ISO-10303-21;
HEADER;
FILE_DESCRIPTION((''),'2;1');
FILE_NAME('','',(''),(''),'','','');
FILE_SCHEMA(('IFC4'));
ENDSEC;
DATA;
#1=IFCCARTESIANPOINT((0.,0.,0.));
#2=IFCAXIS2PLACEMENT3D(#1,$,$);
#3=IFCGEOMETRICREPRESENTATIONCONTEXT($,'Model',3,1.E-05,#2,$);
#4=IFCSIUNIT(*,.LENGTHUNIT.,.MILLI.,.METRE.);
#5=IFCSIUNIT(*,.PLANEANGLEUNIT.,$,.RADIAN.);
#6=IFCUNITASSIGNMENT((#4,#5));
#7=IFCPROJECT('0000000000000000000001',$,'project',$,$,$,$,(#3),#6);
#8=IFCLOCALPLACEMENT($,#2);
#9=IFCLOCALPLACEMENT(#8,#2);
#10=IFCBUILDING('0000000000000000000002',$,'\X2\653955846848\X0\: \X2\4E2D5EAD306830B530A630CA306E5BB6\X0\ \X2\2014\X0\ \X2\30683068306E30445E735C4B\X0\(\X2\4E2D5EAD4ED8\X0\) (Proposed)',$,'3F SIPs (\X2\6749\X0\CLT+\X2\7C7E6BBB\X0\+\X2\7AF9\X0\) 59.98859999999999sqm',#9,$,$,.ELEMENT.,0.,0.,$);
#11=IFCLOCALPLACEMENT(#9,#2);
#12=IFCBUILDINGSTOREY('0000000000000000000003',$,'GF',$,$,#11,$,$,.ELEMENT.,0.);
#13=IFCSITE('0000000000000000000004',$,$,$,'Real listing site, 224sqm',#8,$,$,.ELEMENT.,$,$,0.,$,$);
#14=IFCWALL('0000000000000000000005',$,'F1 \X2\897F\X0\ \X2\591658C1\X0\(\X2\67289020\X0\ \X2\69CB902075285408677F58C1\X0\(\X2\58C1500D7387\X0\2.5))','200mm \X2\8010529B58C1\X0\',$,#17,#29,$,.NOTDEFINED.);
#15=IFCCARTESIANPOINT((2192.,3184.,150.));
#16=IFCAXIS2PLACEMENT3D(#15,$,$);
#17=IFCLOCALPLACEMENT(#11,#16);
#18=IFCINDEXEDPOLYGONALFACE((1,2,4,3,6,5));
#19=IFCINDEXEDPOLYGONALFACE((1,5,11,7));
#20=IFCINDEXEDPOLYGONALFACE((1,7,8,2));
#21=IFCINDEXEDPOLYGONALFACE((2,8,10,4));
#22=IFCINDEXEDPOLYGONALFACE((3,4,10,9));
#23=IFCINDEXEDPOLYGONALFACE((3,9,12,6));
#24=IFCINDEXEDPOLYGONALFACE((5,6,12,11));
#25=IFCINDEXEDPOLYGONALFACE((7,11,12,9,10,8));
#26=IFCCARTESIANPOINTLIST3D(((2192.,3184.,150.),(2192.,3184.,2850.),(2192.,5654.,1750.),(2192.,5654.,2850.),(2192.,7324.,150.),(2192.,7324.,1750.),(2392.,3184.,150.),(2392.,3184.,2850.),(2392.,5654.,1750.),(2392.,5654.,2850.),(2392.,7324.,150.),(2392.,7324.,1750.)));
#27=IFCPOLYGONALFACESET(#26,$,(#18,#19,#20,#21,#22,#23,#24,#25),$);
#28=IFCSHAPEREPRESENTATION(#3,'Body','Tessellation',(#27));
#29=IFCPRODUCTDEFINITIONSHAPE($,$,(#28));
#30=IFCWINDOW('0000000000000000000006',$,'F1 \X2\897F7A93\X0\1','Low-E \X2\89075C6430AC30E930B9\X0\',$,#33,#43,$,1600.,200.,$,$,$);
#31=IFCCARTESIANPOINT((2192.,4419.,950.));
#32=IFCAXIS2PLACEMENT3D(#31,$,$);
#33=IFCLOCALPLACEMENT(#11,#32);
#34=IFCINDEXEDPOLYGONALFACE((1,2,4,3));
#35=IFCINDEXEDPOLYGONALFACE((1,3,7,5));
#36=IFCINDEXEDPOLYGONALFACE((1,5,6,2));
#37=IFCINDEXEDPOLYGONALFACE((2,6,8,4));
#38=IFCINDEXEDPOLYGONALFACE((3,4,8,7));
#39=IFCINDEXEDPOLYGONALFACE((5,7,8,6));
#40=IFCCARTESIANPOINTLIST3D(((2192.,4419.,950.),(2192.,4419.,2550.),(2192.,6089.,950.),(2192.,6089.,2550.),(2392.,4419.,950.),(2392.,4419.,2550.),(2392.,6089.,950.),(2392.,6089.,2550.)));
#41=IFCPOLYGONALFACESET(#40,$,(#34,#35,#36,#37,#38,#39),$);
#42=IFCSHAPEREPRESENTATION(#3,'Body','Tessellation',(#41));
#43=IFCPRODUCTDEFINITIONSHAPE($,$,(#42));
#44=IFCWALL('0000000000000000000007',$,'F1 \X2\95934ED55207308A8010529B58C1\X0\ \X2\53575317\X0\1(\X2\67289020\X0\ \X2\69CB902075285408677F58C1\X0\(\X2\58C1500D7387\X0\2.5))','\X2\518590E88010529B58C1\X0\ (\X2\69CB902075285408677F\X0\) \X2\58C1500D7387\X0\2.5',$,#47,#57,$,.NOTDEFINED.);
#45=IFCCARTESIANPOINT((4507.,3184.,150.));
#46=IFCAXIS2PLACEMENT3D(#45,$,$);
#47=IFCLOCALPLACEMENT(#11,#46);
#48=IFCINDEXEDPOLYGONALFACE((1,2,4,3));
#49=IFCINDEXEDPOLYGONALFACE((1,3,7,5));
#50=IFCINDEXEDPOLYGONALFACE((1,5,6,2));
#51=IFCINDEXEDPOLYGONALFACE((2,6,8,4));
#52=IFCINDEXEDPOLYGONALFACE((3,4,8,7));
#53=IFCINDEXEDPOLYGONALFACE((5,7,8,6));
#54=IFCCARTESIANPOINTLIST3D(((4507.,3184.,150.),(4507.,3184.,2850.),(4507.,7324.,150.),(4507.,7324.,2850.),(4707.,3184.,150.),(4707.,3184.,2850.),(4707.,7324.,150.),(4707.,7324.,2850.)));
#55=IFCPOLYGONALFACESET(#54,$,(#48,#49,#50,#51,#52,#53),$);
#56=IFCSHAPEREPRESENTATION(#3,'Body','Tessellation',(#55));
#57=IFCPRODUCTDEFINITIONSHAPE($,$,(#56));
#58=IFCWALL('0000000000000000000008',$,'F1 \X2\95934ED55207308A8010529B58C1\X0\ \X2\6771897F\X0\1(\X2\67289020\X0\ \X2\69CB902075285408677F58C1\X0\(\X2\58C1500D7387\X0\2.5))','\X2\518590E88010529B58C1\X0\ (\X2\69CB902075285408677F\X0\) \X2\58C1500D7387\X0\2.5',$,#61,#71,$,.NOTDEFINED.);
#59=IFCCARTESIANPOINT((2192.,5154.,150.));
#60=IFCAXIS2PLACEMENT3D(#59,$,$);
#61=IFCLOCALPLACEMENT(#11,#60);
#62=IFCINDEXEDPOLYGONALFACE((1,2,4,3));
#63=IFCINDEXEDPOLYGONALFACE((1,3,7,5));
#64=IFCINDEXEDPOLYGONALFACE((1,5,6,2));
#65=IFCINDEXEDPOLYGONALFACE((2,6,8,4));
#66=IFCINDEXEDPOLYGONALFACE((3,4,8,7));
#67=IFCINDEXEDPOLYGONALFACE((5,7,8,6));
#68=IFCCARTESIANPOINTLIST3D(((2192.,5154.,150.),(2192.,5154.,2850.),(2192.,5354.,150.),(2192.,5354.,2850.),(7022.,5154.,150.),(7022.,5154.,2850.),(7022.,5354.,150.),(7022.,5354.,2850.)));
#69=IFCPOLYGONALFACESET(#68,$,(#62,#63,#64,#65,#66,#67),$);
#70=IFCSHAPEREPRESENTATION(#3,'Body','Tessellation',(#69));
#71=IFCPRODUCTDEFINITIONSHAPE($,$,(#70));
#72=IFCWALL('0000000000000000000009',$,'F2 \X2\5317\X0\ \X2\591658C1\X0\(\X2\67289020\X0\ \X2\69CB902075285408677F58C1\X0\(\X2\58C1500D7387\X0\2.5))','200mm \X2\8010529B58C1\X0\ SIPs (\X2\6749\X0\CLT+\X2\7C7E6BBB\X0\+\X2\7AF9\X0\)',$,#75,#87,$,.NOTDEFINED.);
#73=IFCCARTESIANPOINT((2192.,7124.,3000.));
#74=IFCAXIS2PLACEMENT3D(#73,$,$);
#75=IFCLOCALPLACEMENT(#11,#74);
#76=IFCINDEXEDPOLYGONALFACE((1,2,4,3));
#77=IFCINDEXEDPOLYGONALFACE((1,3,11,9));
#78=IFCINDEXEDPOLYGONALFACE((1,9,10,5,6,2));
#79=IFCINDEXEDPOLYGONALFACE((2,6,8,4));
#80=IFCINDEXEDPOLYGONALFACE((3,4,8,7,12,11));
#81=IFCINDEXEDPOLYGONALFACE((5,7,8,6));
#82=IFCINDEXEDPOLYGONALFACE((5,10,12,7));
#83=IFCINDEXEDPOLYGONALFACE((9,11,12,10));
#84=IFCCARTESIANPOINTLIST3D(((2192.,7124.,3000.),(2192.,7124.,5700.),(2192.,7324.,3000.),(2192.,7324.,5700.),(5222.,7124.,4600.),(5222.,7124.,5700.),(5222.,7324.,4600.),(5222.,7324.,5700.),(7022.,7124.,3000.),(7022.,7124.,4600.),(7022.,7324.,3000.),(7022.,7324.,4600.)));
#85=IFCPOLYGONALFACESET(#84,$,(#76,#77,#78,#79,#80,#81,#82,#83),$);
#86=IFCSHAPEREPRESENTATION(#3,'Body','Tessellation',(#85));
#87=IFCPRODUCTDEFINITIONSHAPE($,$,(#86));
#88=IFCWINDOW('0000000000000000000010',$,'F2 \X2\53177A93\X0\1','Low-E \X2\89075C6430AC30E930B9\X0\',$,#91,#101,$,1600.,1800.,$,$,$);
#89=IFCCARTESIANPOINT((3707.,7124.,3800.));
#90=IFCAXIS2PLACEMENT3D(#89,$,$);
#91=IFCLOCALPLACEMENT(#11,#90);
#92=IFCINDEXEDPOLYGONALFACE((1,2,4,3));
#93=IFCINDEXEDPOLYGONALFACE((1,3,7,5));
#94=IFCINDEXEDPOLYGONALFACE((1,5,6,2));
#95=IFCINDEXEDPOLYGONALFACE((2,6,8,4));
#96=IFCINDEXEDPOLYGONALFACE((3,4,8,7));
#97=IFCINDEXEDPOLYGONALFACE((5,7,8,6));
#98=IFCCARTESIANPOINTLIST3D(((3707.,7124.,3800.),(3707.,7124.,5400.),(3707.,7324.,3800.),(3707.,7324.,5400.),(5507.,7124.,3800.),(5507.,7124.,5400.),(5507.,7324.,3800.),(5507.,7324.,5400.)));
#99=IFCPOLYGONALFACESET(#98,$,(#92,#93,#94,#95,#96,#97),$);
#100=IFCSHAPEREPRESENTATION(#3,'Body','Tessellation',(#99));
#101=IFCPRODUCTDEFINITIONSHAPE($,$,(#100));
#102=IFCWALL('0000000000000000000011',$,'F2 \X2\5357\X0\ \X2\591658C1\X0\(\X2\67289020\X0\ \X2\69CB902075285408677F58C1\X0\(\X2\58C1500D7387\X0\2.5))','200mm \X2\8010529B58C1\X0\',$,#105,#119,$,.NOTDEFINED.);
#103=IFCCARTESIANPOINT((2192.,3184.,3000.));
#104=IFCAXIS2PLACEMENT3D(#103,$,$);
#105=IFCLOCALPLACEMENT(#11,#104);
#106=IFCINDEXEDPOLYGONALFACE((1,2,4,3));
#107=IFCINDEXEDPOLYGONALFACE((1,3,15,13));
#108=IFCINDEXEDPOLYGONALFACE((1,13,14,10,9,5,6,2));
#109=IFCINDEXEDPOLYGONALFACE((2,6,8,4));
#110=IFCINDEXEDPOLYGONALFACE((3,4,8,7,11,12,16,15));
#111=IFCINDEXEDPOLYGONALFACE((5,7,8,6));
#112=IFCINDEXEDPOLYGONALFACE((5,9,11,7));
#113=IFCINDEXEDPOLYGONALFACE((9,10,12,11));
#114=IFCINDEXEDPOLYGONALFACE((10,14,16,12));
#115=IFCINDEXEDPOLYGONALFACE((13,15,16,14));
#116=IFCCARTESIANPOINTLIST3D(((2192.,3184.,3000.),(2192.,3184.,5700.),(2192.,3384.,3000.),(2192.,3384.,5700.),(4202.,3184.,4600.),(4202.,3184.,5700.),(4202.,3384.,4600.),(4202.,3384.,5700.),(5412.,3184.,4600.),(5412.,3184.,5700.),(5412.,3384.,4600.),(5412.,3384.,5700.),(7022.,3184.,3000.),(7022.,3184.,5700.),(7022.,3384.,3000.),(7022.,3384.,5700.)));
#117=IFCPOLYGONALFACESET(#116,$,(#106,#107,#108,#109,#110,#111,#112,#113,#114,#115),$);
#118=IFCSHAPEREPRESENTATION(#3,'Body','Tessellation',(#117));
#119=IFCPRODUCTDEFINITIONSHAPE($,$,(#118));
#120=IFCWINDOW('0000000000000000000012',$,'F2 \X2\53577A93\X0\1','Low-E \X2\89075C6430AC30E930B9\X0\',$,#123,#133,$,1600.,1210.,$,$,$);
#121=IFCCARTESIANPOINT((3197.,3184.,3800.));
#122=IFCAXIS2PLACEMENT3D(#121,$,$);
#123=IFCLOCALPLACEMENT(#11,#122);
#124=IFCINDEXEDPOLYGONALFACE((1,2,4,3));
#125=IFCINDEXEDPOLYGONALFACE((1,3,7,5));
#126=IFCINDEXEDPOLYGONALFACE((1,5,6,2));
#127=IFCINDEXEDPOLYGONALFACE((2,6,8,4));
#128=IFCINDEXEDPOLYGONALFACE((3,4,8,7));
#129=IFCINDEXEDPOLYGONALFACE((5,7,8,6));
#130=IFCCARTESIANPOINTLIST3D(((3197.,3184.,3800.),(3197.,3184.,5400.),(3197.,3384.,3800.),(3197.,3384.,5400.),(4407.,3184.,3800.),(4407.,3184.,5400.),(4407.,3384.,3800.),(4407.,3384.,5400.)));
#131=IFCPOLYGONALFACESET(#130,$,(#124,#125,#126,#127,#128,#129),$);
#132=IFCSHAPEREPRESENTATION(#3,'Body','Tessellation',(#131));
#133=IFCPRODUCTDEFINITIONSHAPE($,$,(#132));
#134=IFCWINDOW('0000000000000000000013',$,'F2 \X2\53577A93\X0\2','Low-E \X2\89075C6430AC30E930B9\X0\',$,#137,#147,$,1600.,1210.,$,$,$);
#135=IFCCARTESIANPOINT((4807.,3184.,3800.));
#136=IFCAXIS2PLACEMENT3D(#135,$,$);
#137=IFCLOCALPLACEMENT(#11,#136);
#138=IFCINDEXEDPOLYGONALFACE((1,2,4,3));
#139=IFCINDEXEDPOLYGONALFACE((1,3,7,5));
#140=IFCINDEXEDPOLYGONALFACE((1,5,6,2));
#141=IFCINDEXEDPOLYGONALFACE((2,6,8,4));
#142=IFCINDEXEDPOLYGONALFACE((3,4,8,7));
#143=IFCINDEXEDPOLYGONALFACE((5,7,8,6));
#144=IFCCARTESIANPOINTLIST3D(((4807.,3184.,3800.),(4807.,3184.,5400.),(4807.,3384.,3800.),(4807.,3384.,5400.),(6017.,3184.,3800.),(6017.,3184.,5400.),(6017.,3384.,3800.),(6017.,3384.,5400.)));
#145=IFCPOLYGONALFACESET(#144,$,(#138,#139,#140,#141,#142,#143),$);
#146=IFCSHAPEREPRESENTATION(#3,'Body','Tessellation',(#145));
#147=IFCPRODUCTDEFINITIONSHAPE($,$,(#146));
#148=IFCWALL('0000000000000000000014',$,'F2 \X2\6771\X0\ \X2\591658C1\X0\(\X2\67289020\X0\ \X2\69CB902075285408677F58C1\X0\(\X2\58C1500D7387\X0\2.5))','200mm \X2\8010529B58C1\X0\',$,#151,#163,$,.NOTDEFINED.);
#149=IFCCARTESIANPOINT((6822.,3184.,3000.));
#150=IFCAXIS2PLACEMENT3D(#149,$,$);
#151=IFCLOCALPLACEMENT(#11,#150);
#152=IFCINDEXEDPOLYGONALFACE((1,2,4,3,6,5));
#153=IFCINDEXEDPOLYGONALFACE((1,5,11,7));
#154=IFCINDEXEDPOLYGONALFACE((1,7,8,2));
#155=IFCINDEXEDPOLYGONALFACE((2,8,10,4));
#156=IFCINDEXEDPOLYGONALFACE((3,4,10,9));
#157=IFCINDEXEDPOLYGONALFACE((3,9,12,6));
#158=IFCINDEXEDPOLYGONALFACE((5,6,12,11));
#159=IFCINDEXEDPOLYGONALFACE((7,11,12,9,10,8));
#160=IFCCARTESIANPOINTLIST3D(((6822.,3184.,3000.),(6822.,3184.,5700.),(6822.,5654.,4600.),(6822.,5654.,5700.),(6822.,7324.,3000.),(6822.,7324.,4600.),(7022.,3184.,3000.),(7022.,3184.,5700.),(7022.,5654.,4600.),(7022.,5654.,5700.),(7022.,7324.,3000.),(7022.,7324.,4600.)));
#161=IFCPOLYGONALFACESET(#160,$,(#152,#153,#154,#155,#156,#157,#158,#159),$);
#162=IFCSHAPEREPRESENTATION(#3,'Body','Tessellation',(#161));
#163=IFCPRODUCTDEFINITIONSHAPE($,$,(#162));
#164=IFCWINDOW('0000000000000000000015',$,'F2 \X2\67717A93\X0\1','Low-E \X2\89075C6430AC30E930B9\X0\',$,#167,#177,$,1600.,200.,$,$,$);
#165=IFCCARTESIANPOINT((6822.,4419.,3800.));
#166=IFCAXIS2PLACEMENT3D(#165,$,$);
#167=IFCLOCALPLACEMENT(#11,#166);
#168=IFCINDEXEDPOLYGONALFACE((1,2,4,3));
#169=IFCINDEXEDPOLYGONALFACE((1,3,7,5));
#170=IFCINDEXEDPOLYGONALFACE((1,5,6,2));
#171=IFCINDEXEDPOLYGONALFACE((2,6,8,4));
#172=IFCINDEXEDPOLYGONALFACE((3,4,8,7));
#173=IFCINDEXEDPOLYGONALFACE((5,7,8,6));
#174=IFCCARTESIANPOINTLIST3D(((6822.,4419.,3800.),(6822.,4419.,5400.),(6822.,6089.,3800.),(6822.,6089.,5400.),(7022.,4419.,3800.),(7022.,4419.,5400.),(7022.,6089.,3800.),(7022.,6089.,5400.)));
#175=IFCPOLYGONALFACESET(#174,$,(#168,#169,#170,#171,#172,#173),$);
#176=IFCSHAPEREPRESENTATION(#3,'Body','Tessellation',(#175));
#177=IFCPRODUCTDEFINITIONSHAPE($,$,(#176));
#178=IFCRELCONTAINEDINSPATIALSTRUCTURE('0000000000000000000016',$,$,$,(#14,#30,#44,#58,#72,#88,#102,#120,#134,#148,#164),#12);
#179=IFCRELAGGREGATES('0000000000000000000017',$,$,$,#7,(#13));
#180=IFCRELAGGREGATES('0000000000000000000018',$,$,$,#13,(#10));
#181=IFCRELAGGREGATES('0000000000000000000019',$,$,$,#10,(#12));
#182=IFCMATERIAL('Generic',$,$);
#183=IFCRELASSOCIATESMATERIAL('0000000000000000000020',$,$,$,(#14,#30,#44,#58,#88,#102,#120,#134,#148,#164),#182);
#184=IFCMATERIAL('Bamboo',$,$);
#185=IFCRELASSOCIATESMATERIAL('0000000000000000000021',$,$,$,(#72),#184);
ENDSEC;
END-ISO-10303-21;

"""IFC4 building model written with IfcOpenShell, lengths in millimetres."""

from ifc_helpers import new_model, si_unit, frame, frame_2d, origin, place, context, project, spatial, rectangle, extrude, material, element, fill, save


model = new_model("IFC4")

# Units and contexts
model_context = context("Model", 3, precision=1e-05, world=origin())
ifc_project = project(units=[si_unit("LENGTHUNIT", "METRE", prefix="MILLI"), si_unit("PLANEANGLEUNIT", "RADIAN")], contexts=[model_context])

# Site, building, storey
site_placement = place(None, origin())
site = spatial("IfcSite", under=ifc_project, at=site_placement, ObjectType="Real listing site, 224sqm", CompositionType="ELEMENT", RefElevation=0.0)
building_placement = place(site_placement, origin())
building = spatial("IfcBuilding", under=site, at=building_placement, Name="改善案: 中庭とサウナの家 — ととのい平屋(中庭付) (Proposed)", ObjectType="3F SIPs (杉CLT+籾殻+竹) 59.98859999999999sqm", CompositionType="ELEMENT", ElevationOfRefHeight=0.0, ElevationOfTerrain=0.0)
storey_placement = place(building_placement, origin())
storey = spatial("IfcBuildingStorey", under=building, at=storey_placement, Name="GF", CompositionType="ELEMENT", Elevation=0.0)

# Shared definitions
ifc_material_1 = material(Name="Generic")

# Shared definitions
ifc_material_2 = material(Name="Bamboo")

# Wall, opening, window
wall_1_placement = place(storey_placement, frame((2192.0, 3184.0, 150.0)))
wall_1 = element("IfcWall", 1, at=wall_1_placement, inside=storey, material=ifc_material_1, Name="F1 西 外壁(木造 構造用合板壁(壁倍率2.5))", Description="200mm 耐力壁", PredefinedType="NOTDEFINED", context=model_context, shape_type="SweptSolid", body=[
    extrude(rectangle(XDim=200.0, YDim=4140.0, at=frame_2d((100.0, 2070.0))), frame((2192.0, 3184.0, 150.0)), (0.0, 0.0, 1.0), 2700.0),
])
opening_1_placement = place(storey_placement, frame((2192.0, 4419.0, 950.0)))
opening_1 = element("IfcOpeningElement", 2, at=opening_1_placement, cuts=wall_1, PredefinedType="NOTDEFINED", context=model_context, shape_type="SweptSolid", body=[
    extrude(rectangle(XDim=200.0, YDim=1670.0, at=frame_2d((100.0, 835.0))), frame((2192.0, 4419.0, 950.0)), (0.0, 0.0, 1.0), 1600.0),
])
window_1_placement = place(storey_placement, frame((2192.0, 4419.0, 950.0)))
window_1 = element("IfcWindow", 3, at=window_1_placement, inside=storey, material=ifc_material_1, Name="F1 西窓1", Description="Low-E 複層ガラス", OverallHeight=1600.0, OverallWidth=200.0, context=model_context, shape_type="SweptSolid", body=[
    extrude(rectangle(XDim=200.0, YDim=1670.0, at=frame_2d((100.0, 835.0))), frame((2192.0, 4419.0, 950.0)), (0.0, 0.0, 1.0), 1600.0),
])
fill(opening_1, window_1)

# Walls
wall_2_placement = place(storey_placement, frame((4507.0, 3184.0, 150.0)))
element("IfcWall", 4, at=wall_2_placement, inside=storey, material=ifc_material_1, Name="F1 間仕切り耐力壁 南北1(木造 構造用合板壁(壁倍率2.5))", Description="内部耐力壁 (構造用合板) 壁倍率2.5", PredefinedType="NOTDEFINED", context=model_context, shape_type="SweptSolid", body=[
    extrude(rectangle(XDim=200.0, YDim=4140.0, at=frame_2d((100.0, 2070.0))), frame((4507.0, 3184.0, 150.0)), (0.0, 0.0, 1.0), 2700.0),
])
wall_3_placement = place(storey_placement, frame((2192.0, 5154.0, 150.0)))
element("IfcWall", 5, at=wall_3_placement, inside=storey, material=ifc_material_1, Name="F1 間仕切り耐力壁 東西1(木造 構造用合板壁(壁倍率2.5))", Description="内部耐力壁 (構造用合板) 壁倍率2.5", PredefinedType="NOTDEFINED", context=model_context, shape_type="SweptSolid", body=[
    extrude(rectangle(XDim=4830.0, YDim=200.0, at=frame_2d((2415.0, 100.0))), frame((2192.0, 5154.0, 150.0)), (0.0, 0.0, 1.0), 2700.0),
])

# Wall, opening, window
wall_4_placement = place(storey_placement, frame((2192.0, 7124.0, 3000.0)))
wall_4 = element("IfcWall", 6, at=wall_4_placement, inside=storey, material=ifc_material_2, Name="F2 北 外壁(木造 構造用合板壁(壁倍率2.5))", Description="200mm 耐力壁 SIPs (杉CLT+籾殻+竹)", PredefinedType="NOTDEFINED", context=model_context, shape_type="SweptSolid", body=[
    extrude(rectangle(XDim=4830.0, YDim=200.0, at=frame_2d((2415.0, 100.0))), frame((2192.0, 7124.0, 3000.0)), (0.0, 0.0, 1.0), 2700.0),
])
opening_2_placement = place(storey_placement, frame((3707.0, 7124.0, 3800.0)))
opening_2 = element("IfcOpeningElement", 7, at=opening_2_placement, cuts=wall_4, PredefinedType="NOTDEFINED", context=model_context, shape_type="SweptSolid", body=[
    extrude(rectangle(XDim=1800.0, YDim=200.0, at=frame_2d((900.0, 100.0))), frame((3707.0, 7124.0, 3800.0)), (0.0, 0.0, 1.0), 1600.0),
])
window_2_placement = place(storey_placement, frame((3707.0, 7124.0, 3800.0)))
window_2 = element("IfcWindow", 8, at=window_2_placement, inside=storey, material=ifc_material_1, Name="F2 北窓1", Description="Low-E 複層ガラス", OverallHeight=1600.0, OverallWidth=1800.0, context=model_context, shape_type="SweptSolid", body=[
    extrude(rectangle(XDim=1800.0, YDim=200.0, at=frame_2d((900.0, 100.0))), frame((3707.0, 7124.0, 3800.0)), (0.0, 0.0, 1.0), 1600.0),
])
fill(opening_2, window_2)

# Wall, openings, windows
wall_5_placement = place(storey_placement, frame((2192.0, 3184.0, 3000.0)))
wall_5 = element("IfcWall", 9, at=wall_5_placement, inside=storey, material=ifc_material_1, Name="F2 南 外壁(木造 構造用合板壁(壁倍率2.5))", Description="200mm 耐力壁", PredefinedType="NOTDEFINED", context=model_context, shape_type="SweptSolid", body=[
    extrude(rectangle(XDim=4830.0, YDim=200.0, at=frame_2d((2415.0, 100.0))), frame((2192.0, 3184.0, 3000.0)), (0.0, 0.0, 1.0), 2700.0),
])
opening_3_placement = place(storey_placement, frame((3197.0, 3184.0, 3800.0)))
opening_3 = element("IfcOpeningElement", 10, at=opening_3_placement, cuts=wall_5, PredefinedType="NOTDEFINED", context=model_context, shape_type="SweptSolid", body=[
    extrude(rectangle(XDim=1210.0, YDim=200.0, at=frame_2d((605.0, 100.0))), frame((3197.0, 3184.0, 3800.0)), (0.0, 0.0, 1.0), 1600.0),
])
opening_4_placement = place(storey_placement, frame((4807.0, 3184.0, 3800.0)))
opening_4 = element("IfcOpeningElement", 11, at=opening_4_placement, cuts=wall_5, PredefinedType="NOTDEFINED", context=model_context, shape_type="SweptSolid", body=[
    extrude(rectangle(XDim=1210.0, YDim=200.0, at=frame_2d((605.0, 100.0))), frame((4807.0, 3184.0, 3800.0)), (0.0, 0.0, 1.0), 1600.0),
])
window_3_placement = place(storey_placement, frame((3197.0, 3184.0, 3800.0)))
window_3 = element("IfcWindow", 12, at=window_3_placement, inside=storey, material=ifc_material_1, Name="F2 南窓1", Description="Low-E 複層ガラス", OverallHeight=1600.0, OverallWidth=1210.0, context=model_context, shape_type="SweptSolid", body=[
    extrude(rectangle(XDim=1210.0, YDim=200.0, at=frame_2d((605.0, 100.0))), frame((3197.0, 3184.0, 3800.0)), (0.0, 0.0, 1.0), 1600.0),
])
fill(opening_3, window_3)
window_4_placement = place(storey_placement, frame((4807.0, 3184.0, 3800.0)))
window_4 = element("IfcWindow", 13, at=window_4_placement, inside=storey, material=ifc_material_1, Name="F2 南窓2", Description="Low-E 複層ガラス", OverallHeight=1600.0, OverallWidth=1210.0, context=model_context, shape_type="SweptSolid", body=[
    extrude(rectangle(XDim=1210.0, YDim=200.0, at=frame_2d((605.0, 100.0))), frame((4807.0, 3184.0, 3800.0)), (0.0, 0.0, 1.0), 1600.0),
])
fill(opening_4, window_4)

# Wall, opening, window
wall_6_placement = place(storey_placement, frame((6822.0, 3184.0, 3000.0)))
wall_6 = element("IfcWall", 14, at=wall_6_placement, inside=storey, material=ifc_material_1, Name="F2 東 外壁(木造 構造用合板壁(壁倍率2.5))", Description="200mm 耐力壁", PredefinedType="NOTDEFINED", context=model_context, shape_type="SweptSolid", body=[
    extrude(rectangle(XDim=200.0, YDim=4140.0, at=frame_2d((100.0, 2070.0))), frame((6822.0, 3184.0, 3000.0)), (0.0, 0.0, 1.0), 2700.0),
])
opening_5_placement = place(storey_placement, frame((6822.0, 4419.0, 3800.0)))
opening_5 = element("IfcOpeningElement", 15, at=opening_5_placement, cuts=wall_6, PredefinedType="NOTDEFINED", context=model_context, shape_type="SweptSolid", body=[
    extrude(rectangle(XDim=200.0, YDim=1670.0, at=frame_2d((100.0, 835.0))), frame((6822.0, 4419.0, 3800.0)), (0.0, 0.0, 1.0), 1600.0),
])
window_5_placement = place(storey_placement, frame((6822.0, 4419.0, 3800.0)))
window_5 = element("IfcWindow", 16, at=window_5_placement, inside=storey, material=ifc_material_1, Name="F2 東窓1", Description="Low-E 複層ガラス", OverallHeight=1600.0, OverallWidth=200.0, context=model_context, shape_type="SweptSolid", body=[
    extrude(rectangle(XDim=200.0, YDim=1670.0, at=frame_2d((100.0, 835.0))), frame((6822.0, 4419.0, 3800.0)), (0.0, 0.0, 1.0), 1600.0),
])
fill(opening_5, window_5)

save(model, "model.ifc")
